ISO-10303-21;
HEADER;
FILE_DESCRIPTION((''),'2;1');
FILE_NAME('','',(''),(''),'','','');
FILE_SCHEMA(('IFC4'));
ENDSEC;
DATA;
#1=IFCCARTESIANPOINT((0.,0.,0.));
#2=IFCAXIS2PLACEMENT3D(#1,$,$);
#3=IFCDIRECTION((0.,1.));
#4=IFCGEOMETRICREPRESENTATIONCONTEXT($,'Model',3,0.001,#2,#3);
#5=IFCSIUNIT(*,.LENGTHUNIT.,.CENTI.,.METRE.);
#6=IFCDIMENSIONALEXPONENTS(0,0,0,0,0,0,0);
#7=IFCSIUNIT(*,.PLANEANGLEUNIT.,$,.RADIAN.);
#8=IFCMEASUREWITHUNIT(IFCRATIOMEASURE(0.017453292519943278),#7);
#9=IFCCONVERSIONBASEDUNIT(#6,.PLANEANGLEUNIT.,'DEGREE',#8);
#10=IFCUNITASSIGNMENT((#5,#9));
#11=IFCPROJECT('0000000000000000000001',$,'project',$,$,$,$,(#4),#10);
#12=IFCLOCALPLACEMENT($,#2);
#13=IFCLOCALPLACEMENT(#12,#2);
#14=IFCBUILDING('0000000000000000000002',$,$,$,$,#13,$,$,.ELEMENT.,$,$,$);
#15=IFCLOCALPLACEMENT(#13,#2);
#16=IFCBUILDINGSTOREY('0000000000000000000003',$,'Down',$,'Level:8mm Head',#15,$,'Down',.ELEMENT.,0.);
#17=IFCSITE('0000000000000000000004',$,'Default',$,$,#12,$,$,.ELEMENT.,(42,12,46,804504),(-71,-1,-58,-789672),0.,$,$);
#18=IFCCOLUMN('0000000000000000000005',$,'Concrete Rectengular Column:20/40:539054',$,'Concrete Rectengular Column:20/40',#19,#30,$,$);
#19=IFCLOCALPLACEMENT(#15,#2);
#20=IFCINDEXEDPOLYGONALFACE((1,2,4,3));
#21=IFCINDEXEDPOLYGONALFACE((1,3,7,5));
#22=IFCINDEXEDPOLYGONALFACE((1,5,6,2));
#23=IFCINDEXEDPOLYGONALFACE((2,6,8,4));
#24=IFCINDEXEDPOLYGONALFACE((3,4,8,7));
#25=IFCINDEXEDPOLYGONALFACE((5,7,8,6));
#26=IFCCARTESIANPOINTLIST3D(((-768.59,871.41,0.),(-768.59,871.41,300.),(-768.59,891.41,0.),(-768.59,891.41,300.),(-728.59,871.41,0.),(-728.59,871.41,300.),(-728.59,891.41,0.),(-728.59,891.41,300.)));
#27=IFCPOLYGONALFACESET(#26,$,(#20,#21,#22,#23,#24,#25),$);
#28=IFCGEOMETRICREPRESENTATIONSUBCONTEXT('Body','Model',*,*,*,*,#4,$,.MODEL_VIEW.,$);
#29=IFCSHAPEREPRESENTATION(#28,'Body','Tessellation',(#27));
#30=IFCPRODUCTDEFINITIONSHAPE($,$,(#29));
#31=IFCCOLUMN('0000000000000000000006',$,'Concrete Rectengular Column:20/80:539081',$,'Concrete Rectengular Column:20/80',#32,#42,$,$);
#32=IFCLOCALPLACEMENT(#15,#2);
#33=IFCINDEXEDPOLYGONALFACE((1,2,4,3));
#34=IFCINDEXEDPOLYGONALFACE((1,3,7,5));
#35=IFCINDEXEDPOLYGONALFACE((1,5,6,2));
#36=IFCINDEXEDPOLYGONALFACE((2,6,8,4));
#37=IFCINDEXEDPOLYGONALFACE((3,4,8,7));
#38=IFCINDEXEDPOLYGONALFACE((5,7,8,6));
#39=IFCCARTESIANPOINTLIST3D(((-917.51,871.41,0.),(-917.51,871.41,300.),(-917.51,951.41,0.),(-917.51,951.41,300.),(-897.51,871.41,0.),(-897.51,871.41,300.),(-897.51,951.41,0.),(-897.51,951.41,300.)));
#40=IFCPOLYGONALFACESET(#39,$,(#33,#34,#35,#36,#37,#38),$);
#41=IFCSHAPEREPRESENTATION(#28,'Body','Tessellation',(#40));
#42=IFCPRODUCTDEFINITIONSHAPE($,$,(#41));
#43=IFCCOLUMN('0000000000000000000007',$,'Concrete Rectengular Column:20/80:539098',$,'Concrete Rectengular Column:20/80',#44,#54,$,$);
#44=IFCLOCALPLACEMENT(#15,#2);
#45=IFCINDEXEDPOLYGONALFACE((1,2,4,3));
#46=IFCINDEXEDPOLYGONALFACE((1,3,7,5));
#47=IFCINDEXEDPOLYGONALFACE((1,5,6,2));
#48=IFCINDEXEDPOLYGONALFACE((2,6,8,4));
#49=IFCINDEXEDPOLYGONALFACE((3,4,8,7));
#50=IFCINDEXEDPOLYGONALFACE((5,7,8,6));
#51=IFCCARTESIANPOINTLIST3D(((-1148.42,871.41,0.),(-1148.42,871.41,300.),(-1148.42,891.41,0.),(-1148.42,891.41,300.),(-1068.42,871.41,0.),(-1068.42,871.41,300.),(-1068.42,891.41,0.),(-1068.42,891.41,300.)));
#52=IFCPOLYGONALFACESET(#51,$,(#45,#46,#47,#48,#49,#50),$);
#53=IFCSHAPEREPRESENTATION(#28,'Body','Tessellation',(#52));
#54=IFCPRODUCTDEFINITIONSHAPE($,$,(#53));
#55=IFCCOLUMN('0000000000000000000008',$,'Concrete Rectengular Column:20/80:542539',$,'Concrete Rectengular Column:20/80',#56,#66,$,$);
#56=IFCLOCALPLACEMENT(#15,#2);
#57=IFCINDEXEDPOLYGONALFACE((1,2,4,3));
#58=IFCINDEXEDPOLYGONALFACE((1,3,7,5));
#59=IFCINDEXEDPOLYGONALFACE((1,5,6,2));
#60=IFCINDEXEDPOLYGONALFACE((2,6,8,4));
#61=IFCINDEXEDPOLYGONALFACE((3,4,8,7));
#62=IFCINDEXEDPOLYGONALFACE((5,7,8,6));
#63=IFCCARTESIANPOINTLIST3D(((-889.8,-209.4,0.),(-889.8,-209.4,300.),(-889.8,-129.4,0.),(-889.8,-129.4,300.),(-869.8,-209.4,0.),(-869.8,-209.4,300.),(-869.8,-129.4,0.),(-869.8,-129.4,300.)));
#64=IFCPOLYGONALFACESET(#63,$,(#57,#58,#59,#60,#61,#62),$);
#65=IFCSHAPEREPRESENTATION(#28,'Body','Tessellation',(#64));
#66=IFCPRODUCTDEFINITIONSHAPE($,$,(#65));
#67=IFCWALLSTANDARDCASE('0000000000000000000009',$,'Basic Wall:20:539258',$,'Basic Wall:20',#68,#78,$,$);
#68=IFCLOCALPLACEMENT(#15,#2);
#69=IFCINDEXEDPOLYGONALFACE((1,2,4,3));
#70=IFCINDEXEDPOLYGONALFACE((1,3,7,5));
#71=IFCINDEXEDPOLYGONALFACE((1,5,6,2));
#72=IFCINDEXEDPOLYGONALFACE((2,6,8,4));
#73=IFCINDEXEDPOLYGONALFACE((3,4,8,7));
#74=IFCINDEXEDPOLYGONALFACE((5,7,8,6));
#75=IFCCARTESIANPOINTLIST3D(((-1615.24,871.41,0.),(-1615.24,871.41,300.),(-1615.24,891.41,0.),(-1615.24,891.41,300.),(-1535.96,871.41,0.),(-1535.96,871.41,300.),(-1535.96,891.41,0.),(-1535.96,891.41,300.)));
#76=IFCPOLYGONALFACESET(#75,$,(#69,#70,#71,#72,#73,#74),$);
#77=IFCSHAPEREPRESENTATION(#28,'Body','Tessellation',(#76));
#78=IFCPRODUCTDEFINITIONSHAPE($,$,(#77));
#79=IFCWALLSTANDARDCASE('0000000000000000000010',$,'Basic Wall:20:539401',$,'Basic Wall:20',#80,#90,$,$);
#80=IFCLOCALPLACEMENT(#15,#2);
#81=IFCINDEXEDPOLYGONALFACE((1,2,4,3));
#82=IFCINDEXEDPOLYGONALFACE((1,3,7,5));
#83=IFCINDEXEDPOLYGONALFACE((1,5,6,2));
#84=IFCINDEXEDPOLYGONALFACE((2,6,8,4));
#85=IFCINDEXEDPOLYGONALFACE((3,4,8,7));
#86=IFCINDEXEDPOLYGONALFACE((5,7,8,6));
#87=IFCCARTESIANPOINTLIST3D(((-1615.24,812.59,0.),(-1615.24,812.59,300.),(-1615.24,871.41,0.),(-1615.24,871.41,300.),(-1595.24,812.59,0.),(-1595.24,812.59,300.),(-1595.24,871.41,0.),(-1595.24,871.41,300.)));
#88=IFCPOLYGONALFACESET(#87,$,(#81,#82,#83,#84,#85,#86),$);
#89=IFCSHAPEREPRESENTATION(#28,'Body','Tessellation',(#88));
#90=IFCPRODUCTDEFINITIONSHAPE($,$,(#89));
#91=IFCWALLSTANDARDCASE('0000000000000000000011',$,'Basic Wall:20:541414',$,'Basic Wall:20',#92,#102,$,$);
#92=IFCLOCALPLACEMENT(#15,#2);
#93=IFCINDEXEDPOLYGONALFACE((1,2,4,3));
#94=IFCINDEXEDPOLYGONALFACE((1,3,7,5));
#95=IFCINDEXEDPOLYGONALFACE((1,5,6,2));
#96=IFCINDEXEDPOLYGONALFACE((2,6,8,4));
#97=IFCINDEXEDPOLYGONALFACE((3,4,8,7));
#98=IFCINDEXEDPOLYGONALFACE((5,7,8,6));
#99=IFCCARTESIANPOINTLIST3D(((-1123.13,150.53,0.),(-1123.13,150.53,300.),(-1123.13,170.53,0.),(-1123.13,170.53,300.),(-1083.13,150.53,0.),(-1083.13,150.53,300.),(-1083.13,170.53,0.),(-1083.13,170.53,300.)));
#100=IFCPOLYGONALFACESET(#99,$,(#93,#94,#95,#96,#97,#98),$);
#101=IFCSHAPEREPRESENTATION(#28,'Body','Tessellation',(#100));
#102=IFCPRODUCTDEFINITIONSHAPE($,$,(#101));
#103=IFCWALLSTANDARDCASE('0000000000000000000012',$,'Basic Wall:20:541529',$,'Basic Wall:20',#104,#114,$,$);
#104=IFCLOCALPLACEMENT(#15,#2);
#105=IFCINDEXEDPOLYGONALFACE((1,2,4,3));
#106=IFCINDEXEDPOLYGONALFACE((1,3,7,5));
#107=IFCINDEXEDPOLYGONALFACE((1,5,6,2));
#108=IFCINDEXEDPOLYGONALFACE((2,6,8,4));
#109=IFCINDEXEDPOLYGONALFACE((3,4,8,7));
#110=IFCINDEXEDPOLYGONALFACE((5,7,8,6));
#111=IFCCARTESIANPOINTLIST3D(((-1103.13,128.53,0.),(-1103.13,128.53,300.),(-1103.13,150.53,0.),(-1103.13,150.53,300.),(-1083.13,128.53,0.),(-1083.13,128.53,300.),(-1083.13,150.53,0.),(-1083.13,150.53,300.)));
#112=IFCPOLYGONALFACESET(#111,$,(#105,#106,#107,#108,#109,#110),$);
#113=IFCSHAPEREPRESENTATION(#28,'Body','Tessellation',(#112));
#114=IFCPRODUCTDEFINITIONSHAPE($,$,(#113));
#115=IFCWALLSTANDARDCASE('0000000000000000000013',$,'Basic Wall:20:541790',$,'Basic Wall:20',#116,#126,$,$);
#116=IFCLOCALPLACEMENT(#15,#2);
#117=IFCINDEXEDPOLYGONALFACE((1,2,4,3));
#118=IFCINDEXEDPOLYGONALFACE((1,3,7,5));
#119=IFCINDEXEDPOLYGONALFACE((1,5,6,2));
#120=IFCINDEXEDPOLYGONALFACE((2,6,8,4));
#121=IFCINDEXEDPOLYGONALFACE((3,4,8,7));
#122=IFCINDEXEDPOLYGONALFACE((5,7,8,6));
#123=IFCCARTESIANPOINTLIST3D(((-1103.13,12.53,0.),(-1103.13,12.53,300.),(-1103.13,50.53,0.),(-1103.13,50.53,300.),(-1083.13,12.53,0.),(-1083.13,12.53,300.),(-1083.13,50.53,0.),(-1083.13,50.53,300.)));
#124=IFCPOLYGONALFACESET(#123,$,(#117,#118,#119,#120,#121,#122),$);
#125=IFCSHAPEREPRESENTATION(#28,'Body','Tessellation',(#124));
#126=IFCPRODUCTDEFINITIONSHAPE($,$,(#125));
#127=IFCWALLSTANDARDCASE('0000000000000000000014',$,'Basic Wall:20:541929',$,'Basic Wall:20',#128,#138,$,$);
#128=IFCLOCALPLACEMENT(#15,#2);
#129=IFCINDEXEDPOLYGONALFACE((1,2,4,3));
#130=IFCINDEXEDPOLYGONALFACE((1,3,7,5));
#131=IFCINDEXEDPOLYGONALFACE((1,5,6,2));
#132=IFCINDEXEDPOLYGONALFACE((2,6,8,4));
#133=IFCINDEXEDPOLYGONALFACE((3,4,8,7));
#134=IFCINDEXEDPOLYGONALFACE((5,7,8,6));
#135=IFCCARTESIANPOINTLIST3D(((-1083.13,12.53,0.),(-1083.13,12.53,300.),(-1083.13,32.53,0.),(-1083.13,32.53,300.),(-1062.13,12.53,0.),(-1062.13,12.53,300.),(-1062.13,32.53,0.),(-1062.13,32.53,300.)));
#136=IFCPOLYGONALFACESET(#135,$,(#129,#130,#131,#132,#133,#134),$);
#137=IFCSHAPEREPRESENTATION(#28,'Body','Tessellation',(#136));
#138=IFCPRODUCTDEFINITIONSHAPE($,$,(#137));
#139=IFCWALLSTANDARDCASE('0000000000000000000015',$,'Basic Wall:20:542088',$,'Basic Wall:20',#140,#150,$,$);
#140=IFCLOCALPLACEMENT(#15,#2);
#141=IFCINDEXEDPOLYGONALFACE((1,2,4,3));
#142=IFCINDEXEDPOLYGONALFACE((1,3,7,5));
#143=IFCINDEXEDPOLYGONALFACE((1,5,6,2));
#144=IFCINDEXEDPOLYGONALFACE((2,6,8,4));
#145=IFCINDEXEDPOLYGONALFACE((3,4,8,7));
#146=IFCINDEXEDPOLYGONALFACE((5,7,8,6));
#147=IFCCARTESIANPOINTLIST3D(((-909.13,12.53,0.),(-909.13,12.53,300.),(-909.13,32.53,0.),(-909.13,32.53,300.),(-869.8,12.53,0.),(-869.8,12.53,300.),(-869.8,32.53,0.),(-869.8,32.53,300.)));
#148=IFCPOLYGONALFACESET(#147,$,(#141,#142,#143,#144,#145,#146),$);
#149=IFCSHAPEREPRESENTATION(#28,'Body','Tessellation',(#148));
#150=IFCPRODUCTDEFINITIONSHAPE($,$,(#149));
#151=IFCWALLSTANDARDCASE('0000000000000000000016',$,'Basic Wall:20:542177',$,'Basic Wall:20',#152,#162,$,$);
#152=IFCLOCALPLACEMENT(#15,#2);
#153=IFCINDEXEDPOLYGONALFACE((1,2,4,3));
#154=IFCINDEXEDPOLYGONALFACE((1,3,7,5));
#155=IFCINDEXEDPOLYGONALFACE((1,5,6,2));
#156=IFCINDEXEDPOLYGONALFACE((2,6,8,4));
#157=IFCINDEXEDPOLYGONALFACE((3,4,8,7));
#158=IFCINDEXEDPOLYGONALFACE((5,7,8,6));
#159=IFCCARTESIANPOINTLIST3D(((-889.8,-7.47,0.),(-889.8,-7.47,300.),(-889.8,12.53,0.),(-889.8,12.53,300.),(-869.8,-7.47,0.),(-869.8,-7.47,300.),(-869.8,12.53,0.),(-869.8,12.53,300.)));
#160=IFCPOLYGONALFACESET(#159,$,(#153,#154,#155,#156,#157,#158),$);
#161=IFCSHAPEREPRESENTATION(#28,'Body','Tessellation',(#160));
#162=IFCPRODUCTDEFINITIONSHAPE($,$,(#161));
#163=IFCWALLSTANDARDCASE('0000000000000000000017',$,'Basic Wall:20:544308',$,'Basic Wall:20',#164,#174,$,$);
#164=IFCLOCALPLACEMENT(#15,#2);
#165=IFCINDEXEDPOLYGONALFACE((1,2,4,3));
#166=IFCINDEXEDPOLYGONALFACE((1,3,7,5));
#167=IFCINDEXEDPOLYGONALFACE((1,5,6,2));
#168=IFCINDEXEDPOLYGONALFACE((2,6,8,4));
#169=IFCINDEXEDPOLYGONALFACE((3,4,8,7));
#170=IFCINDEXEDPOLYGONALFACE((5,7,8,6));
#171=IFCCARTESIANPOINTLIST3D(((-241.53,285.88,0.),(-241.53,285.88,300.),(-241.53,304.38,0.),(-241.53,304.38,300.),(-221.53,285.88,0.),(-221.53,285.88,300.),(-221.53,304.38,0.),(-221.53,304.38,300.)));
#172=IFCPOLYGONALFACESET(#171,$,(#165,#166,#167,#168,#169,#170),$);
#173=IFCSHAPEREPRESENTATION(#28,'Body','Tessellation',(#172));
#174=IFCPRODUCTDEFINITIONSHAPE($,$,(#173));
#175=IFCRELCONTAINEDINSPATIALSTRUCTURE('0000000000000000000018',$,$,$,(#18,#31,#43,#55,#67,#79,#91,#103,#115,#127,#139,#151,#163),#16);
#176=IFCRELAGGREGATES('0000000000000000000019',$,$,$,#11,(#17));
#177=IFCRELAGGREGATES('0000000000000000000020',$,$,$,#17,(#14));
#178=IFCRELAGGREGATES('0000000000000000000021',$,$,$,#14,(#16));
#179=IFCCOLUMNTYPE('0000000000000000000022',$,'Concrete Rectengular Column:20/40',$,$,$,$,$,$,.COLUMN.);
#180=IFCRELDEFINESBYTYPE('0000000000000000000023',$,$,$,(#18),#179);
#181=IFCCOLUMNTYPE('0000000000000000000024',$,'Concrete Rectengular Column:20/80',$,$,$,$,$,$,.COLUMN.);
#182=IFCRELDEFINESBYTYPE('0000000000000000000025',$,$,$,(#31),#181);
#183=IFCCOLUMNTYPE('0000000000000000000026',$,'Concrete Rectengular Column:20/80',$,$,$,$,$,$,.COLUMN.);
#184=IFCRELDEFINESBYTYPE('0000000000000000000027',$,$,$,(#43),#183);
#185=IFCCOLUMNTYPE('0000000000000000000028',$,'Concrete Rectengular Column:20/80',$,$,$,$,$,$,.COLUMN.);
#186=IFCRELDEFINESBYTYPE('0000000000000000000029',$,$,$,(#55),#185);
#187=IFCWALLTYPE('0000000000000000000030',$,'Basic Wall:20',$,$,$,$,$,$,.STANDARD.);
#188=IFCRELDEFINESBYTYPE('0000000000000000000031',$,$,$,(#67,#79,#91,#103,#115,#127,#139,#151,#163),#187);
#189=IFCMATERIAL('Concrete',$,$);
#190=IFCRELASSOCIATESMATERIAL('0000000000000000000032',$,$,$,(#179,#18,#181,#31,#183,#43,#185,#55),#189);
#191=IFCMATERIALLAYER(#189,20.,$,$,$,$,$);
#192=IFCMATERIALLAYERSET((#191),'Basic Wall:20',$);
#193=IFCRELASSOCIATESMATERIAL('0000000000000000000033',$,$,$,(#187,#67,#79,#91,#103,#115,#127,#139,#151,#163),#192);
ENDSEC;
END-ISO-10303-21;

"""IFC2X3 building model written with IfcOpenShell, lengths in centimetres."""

from ifc_helpers import new_model, entity, si_unit, converted_unit, direction, frame, frame_2d, origin, origin_2d_with_axis, place, context, subcontext, project, spatial, rectangle, extrude, source, transform, mapped, material, layer, layer_set, layer_usage, type_object, type_shapes, element, save


model = new_model("IFC2X3")

# Units and contexts
model_context = context("Model", 3, precision=0.001, world=origin(), true_north=direction((0.0, 1.0)))
body_context = subcontext(model_context, "Body", "Model", "MODEL_VIEW")
ifc_project = project(units=[si_unit("LENGTHUNIT", "METRE", prefix="CENTI"), converted_unit("PLANEANGLEUNIT", "DEGREE", entity("IfcRatioMeasure", 0.017453292519943278), si_unit("PLANEANGLEUNIT", "RADIAN"), dimensions=[0, 0, 0, 0, 0, 0, 0])], contexts=[model_context])

# Site, building, storey
site_placement = place(None, origin())
site = spatial("IfcSite", under=ifc_project, at=site_placement, Name="Default", CompositionType="ELEMENT", RefLatitude=(42, 12, 46, 804504), RefLongitude=(-71, -1, -58, -789672), RefElevation=0.0)
building_placement = place(site_placement, origin())
building = spatial("IfcBuilding", under=site, at=building_placement, CompositionType="ELEMENT")
storey_placement = place(building_placement, origin())
storey = spatial("IfcBuildingStorey", under=building, at=storey_placement, Name="Down", ObjectType="Level:8mm Head", LongName="Down", CompositionType="ELEMENT", Elevation=0.0)

# Columns
ifc_material = material(Name="Concrete")
column_type_1 = type_object("IfcColumnType", Name="Concrete Rectengular Column:20/40", PredefinedType="COLUMN", material=ifc_material)
shared_shape_1 = source(origin(), body_context, "Body", "SweptSolid", [
    extrude(rectangle(XDim=20.0, YDim=40.0, at=origin_2d_with_axis()), frame((-748.59, 881.41, 0.0), z_axis=(0.0, 0.0, 1.0), x_axis=(0.0, -1.0, 0.0)), (0.0, 0.0, 1.0), 300.0),
])
type_shapes(column_type_1, [shared_shape_1])
column_1_placement = place(storey_placement, origin())
element("IfcColumn", 1, at=column_1_placement, inside=storey, type_object=column_type_1, material=ifc_material, Name="Concrete Rectengular Column:20/40:539054", ObjectType="Concrete Rectengular Column:20/40", context=body_context, shape_type="MappedRepresentation", body=[
    mapped(shared_shape_1, transform((0.0, 0.0, 0.0), scale=1.0)),
])
column_type_2 = type_object("IfcColumnType", Name="Concrete Rectengular Column:20/80", PredefinedType="COLUMN", material=ifc_material)
shared_shape_2 = source(origin(), body_context, "Body", "SweptSolid", [
    extrude(rectangle(XDim=80.0, YDim=20.0, at=origin_2d_with_axis()), frame((-907.51, 911.41, 0.0), z_axis=(0.0, 0.0, 1.0), x_axis=(0.0, -1.0, 0.0)), (0.0, 0.0, 1.0), 300.0),
])
type_shapes(column_type_2, [shared_shape_2])
column_2_placement = place(storey_placement, origin())
element("IfcColumn", 2, at=column_2_placement, inside=storey, type_object=column_type_2, material=ifc_material, Name="Concrete Rectengular Column:20/80:539081", ObjectType="Concrete Rectengular Column:20/80", context=body_context, shape_type="MappedRepresentation", body=[
    mapped(shared_shape_2, transform((0.0, 0.0, 0.0), scale=1.0)),
])
column_type_3 = type_object("IfcColumnType", Name="Concrete Rectengular Column:20/80", PredefinedType="COLUMN", material=ifc_material)
shared_shape_3 = source(origin(), body_context, "Body", "SweptSolid", [
    extrude(rectangle(XDim=20.0, YDim=80.0, at=origin_2d_with_axis()), frame((-1108.42, 881.41, 0.0), z_axis=(0.0, 0.0, 1.0), x_axis=(0.0, -1.0, 0.0)), (0.0, 0.0, 1.0), 300.0),
])
type_shapes(column_type_3, [shared_shape_3])
column_3_placement = place(storey_placement, origin())
element("IfcColumn", 3, at=column_3_placement, inside=storey, type_object=column_type_3, material=ifc_material, Name="Concrete Rectengular Column:20/80:539098", ObjectType="Concrete Rectengular Column:20/80", context=body_context, shape_type="MappedRepresentation", body=[
    mapped(shared_shape_3, transform((0.0, 0.0, 0.0), scale=1.0)),
])
column_type_4 = type_object("IfcColumnType", Name="Concrete Rectengular Column:20/80", PredefinedType="COLUMN", material=ifc_material)
shared_shape_4 = source(origin(), body_context, "Body", "SweptSolid", [
    extrude(rectangle(XDim=80.0, YDim=20.0, at=frame_2d((0.0, 0.0), x_axis=(1.0, 0.0))), frame((-879.8, -169.4, 0.0), z_axis=(0.0, 0.0, 1.0), x_axis=(0.0, -1.0, 0.0)), (0.0, 0.0, 1.0), 300.0),
])
type_shapes(column_type_4, [shared_shape_4])
column_4_placement = place(storey_placement, origin())
element("IfcColumn", 4, at=column_4_placement, inside=storey, type_object=column_type_4, material=ifc_material, Name="Concrete Rectengular Column:20/80:542539", ObjectType="Concrete Rectengular Column:20/80", context=body_context, shape_type="MappedRepresentation", body=[
    mapped(shared_shape_4, transform((0.0, 0.0, 0.0), scale=1.0)),
])

# Walls
ifc_layer_1 = layer(ifc_material, 20.0)
ifc_layer_set_1 = layer_set([ifc_layer_1], Name="Basic Wall:20")
ifc_layer_usage_1 = layer_usage(ifc_layer_set_1, "AXIS2", "POSITIVE", -10.0)
wall_type_1 = type_object("IfcWallType", Name="Basic Wall:20", PredefinedType="STANDARD", material=ifc_layer_set_1)
wall_1_placement = place(storey_placement, frame((-1535.96, 881.41, 0.0), z_axis=(0.0, 0.0, 1.0), x_axis=(-1.0, 0.0, 0.0)))
element("IfcWallStandardCase", 5, at=wall_1_placement, inside=storey, type_object=wall_type_1, material=ifc_layer_usage_1, Name="Basic Wall:20:539258", ObjectType="Basic Wall:20", context=body_context, shape_type="SweptSolid", body=[
    extrude(rectangle(XDim=79.28, YDim=20.0, at=frame_2d((39.64, 0.0), x_axis=(-1.0, 0.0))), origin(), (0.0, 0.0, 1.0), 300.0),
])
ifc_layer_usage_2 = layer_usage(ifc_layer_set_1, "AXIS2", "POSITIVE", -10.0)
wall_2_placement = place(storey_placement, frame((-1605.24, 871.41, 0.0), z_axis=(0.0, 0.0, 1.0), x_axis=(0.0, -1.0, 0.0)))
element("IfcWallStandardCase", 6, at=wall_2_placement, inside=storey, type_object=wall_type_1, material=ifc_layer_usage_2, Name="Basic Wall:20:539401", ObjectType="Basic Wall:20", context=body_context, shape_type="SweptSolid", body=[
    extrude(rectangle(XDim=58.82, YDim=20.0, at=frame_2d((29.41, 0.0), x_axis=(-1.0, 0.0))), origin(), (0.0, 0.0, 1.0), 300.0),
])
ifc_layer_usage_3 = layer_usage(ifc_layer_set_1, "AXIS2", "POSITIVE", -10.0)
wall_3_placement = place(storey_placement, frame((-1123.13, 160.53, 0.0)))
element("IfcWallStandardCase", 7, at=wall_3_placement, inside=storey, type_object=wall_type_1, material=ifc_layer_usage_3, Name="Basic Wall:20:541414", ObjectType="Basic Wall:20", context=body_context, shape_type="SweptSolid", body=[
    extrude(rectangle(XDim=40.0, YDim=20.0, at=frame_2d((20.0, 0.0), x_axis=(-1.0, 0.0))), origin(), (0.0, 0.0, 1.0), 300.0),
])
ifc_layer_usage_4 = layer_usage(ifc_layer_set_1, "AXIS2", "NEGATIVE", 10.0)
wall_4_placement = place(storey_placement, frame((-1093.13, 150.53, 0.0), z_axis=(0.0, 0.0, 1.0), x_axis=(0.0, -1.0, 0.0)))
element("IfcWallStandardCase", 8, at=wall_4_placement, inside=storey, type_object=wall_type_1, material=ifc_layer_usage_4, Name="Basic Wall:20:541529", ObjectType="Basic Wall:20", context=body_context, shape_type="SweptSolid", body=[
    extrude(rectangle(XDim=22.0, YDim=20.0, at=frame_2d((11.0, 0.0), x_axis=(-1.0, 0.0))), origin(), (0.0, 0.0, 1.0), 300.0),
])
ifc_layer_usage_5 = layer_usage(ifc_layer_set_1, "AXIS2", "NEGATIVE", 10.0)
wall_5_placement = place(storey_placement, frame((-1093.13, 50.53, 0.0), z_axis=(0.0, 0.0, 1.0), x_axis=(0.0, -1.0, 0.0)))
element("IfcWallStandardCase", 9, at=wall_5_placement, inside=storey, type_object=wall_type_1, material=ifc_layer_usage_5, Name="Basic Wall:20:541790", ObjectType="Basic Wall:20", context=body_context, shape_type="SweptSolid", body=[
    extrude(rectangle(XDim=38.0, YDim=20.0, at=frame_2d((19.0, 0.0), x_axis=(-1.0, 0.0))), origin(), (0.0, 0.0, 1.0), 300.0),
])
ifc_layer_usage_6 = layer_usage(ifc_layer_set_1, "AXIS2", "POSITIVE", -10.0)
wall_6_placement = place(storey_placement, frame((-1083.13, 22.53, 0.0)))
element("IfcWallStandardCase", 10, at=wall_6_placement, inside=storey, type_object=wall_type_1, material=ifc_layer_usage_6, Name="Basic Wall:20:541929", ObjectType="Basic Wall:20", context=body_context, shape_type="SweptSolid", body=[
    extrude(rectangle(XDim=21.0, YDim=20.0, at=frame_2d((10.5, 0.0), x_axis=(-1.0, 0.0))), origin(), (0.0, 0.0, 1.0), 300.0),
])
ifc_layer_usage_7 = layer_usage(ifc_layer_set_1, "AXIS2", "POSITIVE", -10.0)
wall_7_placement = place(storey_placement, frame((-909.13, 22.53, 0.0)))
element("IfcWallStandardCase", 11, at=wall_7_placement, inside=storey, type_object=wall_type_1, material=ifc_layer_usage_7, Name="Basic Wall:20:542088", ObjectType="Basic Wall:20", context=body_context, shape_type="SweptSolid", body=[
    extrude(rectangle(XDim=39.33, YDim=20.0, at=frame_2d((19.67, 0.0), x_axis=(-1.0, 0.0))), origin(), (0.0, 0.0, 1.0), 300.0),
])
ifc_layer_usage_8 = layer_usage(ifc_layer_set_1, "AXIS2", "NEGATIVE", 10.0)
wall_8_placement = place(storey_placement, frame((-879.8, 12.53, 0.0), z_axis=(0.0, 0.0, 1.0), x_axis=(0.0, -1.0, 0.0)))
element("IfcWallStandardCase", 12, at=wall_8_placement, inside=storey, type_object=wall_type_1, material=ifc_layer_usage_8, Name="Basic Wall:20:542177", ObjectType="Basic Wall:20", context=body_context, shape_type="SweptSolid", body=[
    extrude(rectangle(XDim=20.0, YDim=20.0, at=frame_2d((10.0, 0.0), x_axis=(-1.0, 0.0))), origin(), (0.0, 0.0, 1.0), 300.0),
])
ifc_layer_usage_9 = layer_usage(ifc_layer_set_1, "AXIS2", "POSITIVE", -10.0)
wall_9_placement = place(storey_placement, frame((-231.53, 285.88, 0.0), z_axis=(0.0, 0.0, 1.0), x_axis=(0.0, 1.0, 0.0)))
element("IfcWallStandardCase", 13, at=wall_9_placement, inside=storey, type_object=wall_type_1, material=ifc_layer_usage_9, Name="Basic Wall:20:544308", ObjectType="Basic Wall:20", context=body_context, shape_type="SweptSolid", body=[
    extrude(rectangle(XDim=18.5, YDim=20.0, at=frame_2d((9.25, 0.0), x_axis=(-1.0, 0.0))), origin(), (0.0, 0.0, 1.0), 300.0),
])

save(model, "model.ifc")
